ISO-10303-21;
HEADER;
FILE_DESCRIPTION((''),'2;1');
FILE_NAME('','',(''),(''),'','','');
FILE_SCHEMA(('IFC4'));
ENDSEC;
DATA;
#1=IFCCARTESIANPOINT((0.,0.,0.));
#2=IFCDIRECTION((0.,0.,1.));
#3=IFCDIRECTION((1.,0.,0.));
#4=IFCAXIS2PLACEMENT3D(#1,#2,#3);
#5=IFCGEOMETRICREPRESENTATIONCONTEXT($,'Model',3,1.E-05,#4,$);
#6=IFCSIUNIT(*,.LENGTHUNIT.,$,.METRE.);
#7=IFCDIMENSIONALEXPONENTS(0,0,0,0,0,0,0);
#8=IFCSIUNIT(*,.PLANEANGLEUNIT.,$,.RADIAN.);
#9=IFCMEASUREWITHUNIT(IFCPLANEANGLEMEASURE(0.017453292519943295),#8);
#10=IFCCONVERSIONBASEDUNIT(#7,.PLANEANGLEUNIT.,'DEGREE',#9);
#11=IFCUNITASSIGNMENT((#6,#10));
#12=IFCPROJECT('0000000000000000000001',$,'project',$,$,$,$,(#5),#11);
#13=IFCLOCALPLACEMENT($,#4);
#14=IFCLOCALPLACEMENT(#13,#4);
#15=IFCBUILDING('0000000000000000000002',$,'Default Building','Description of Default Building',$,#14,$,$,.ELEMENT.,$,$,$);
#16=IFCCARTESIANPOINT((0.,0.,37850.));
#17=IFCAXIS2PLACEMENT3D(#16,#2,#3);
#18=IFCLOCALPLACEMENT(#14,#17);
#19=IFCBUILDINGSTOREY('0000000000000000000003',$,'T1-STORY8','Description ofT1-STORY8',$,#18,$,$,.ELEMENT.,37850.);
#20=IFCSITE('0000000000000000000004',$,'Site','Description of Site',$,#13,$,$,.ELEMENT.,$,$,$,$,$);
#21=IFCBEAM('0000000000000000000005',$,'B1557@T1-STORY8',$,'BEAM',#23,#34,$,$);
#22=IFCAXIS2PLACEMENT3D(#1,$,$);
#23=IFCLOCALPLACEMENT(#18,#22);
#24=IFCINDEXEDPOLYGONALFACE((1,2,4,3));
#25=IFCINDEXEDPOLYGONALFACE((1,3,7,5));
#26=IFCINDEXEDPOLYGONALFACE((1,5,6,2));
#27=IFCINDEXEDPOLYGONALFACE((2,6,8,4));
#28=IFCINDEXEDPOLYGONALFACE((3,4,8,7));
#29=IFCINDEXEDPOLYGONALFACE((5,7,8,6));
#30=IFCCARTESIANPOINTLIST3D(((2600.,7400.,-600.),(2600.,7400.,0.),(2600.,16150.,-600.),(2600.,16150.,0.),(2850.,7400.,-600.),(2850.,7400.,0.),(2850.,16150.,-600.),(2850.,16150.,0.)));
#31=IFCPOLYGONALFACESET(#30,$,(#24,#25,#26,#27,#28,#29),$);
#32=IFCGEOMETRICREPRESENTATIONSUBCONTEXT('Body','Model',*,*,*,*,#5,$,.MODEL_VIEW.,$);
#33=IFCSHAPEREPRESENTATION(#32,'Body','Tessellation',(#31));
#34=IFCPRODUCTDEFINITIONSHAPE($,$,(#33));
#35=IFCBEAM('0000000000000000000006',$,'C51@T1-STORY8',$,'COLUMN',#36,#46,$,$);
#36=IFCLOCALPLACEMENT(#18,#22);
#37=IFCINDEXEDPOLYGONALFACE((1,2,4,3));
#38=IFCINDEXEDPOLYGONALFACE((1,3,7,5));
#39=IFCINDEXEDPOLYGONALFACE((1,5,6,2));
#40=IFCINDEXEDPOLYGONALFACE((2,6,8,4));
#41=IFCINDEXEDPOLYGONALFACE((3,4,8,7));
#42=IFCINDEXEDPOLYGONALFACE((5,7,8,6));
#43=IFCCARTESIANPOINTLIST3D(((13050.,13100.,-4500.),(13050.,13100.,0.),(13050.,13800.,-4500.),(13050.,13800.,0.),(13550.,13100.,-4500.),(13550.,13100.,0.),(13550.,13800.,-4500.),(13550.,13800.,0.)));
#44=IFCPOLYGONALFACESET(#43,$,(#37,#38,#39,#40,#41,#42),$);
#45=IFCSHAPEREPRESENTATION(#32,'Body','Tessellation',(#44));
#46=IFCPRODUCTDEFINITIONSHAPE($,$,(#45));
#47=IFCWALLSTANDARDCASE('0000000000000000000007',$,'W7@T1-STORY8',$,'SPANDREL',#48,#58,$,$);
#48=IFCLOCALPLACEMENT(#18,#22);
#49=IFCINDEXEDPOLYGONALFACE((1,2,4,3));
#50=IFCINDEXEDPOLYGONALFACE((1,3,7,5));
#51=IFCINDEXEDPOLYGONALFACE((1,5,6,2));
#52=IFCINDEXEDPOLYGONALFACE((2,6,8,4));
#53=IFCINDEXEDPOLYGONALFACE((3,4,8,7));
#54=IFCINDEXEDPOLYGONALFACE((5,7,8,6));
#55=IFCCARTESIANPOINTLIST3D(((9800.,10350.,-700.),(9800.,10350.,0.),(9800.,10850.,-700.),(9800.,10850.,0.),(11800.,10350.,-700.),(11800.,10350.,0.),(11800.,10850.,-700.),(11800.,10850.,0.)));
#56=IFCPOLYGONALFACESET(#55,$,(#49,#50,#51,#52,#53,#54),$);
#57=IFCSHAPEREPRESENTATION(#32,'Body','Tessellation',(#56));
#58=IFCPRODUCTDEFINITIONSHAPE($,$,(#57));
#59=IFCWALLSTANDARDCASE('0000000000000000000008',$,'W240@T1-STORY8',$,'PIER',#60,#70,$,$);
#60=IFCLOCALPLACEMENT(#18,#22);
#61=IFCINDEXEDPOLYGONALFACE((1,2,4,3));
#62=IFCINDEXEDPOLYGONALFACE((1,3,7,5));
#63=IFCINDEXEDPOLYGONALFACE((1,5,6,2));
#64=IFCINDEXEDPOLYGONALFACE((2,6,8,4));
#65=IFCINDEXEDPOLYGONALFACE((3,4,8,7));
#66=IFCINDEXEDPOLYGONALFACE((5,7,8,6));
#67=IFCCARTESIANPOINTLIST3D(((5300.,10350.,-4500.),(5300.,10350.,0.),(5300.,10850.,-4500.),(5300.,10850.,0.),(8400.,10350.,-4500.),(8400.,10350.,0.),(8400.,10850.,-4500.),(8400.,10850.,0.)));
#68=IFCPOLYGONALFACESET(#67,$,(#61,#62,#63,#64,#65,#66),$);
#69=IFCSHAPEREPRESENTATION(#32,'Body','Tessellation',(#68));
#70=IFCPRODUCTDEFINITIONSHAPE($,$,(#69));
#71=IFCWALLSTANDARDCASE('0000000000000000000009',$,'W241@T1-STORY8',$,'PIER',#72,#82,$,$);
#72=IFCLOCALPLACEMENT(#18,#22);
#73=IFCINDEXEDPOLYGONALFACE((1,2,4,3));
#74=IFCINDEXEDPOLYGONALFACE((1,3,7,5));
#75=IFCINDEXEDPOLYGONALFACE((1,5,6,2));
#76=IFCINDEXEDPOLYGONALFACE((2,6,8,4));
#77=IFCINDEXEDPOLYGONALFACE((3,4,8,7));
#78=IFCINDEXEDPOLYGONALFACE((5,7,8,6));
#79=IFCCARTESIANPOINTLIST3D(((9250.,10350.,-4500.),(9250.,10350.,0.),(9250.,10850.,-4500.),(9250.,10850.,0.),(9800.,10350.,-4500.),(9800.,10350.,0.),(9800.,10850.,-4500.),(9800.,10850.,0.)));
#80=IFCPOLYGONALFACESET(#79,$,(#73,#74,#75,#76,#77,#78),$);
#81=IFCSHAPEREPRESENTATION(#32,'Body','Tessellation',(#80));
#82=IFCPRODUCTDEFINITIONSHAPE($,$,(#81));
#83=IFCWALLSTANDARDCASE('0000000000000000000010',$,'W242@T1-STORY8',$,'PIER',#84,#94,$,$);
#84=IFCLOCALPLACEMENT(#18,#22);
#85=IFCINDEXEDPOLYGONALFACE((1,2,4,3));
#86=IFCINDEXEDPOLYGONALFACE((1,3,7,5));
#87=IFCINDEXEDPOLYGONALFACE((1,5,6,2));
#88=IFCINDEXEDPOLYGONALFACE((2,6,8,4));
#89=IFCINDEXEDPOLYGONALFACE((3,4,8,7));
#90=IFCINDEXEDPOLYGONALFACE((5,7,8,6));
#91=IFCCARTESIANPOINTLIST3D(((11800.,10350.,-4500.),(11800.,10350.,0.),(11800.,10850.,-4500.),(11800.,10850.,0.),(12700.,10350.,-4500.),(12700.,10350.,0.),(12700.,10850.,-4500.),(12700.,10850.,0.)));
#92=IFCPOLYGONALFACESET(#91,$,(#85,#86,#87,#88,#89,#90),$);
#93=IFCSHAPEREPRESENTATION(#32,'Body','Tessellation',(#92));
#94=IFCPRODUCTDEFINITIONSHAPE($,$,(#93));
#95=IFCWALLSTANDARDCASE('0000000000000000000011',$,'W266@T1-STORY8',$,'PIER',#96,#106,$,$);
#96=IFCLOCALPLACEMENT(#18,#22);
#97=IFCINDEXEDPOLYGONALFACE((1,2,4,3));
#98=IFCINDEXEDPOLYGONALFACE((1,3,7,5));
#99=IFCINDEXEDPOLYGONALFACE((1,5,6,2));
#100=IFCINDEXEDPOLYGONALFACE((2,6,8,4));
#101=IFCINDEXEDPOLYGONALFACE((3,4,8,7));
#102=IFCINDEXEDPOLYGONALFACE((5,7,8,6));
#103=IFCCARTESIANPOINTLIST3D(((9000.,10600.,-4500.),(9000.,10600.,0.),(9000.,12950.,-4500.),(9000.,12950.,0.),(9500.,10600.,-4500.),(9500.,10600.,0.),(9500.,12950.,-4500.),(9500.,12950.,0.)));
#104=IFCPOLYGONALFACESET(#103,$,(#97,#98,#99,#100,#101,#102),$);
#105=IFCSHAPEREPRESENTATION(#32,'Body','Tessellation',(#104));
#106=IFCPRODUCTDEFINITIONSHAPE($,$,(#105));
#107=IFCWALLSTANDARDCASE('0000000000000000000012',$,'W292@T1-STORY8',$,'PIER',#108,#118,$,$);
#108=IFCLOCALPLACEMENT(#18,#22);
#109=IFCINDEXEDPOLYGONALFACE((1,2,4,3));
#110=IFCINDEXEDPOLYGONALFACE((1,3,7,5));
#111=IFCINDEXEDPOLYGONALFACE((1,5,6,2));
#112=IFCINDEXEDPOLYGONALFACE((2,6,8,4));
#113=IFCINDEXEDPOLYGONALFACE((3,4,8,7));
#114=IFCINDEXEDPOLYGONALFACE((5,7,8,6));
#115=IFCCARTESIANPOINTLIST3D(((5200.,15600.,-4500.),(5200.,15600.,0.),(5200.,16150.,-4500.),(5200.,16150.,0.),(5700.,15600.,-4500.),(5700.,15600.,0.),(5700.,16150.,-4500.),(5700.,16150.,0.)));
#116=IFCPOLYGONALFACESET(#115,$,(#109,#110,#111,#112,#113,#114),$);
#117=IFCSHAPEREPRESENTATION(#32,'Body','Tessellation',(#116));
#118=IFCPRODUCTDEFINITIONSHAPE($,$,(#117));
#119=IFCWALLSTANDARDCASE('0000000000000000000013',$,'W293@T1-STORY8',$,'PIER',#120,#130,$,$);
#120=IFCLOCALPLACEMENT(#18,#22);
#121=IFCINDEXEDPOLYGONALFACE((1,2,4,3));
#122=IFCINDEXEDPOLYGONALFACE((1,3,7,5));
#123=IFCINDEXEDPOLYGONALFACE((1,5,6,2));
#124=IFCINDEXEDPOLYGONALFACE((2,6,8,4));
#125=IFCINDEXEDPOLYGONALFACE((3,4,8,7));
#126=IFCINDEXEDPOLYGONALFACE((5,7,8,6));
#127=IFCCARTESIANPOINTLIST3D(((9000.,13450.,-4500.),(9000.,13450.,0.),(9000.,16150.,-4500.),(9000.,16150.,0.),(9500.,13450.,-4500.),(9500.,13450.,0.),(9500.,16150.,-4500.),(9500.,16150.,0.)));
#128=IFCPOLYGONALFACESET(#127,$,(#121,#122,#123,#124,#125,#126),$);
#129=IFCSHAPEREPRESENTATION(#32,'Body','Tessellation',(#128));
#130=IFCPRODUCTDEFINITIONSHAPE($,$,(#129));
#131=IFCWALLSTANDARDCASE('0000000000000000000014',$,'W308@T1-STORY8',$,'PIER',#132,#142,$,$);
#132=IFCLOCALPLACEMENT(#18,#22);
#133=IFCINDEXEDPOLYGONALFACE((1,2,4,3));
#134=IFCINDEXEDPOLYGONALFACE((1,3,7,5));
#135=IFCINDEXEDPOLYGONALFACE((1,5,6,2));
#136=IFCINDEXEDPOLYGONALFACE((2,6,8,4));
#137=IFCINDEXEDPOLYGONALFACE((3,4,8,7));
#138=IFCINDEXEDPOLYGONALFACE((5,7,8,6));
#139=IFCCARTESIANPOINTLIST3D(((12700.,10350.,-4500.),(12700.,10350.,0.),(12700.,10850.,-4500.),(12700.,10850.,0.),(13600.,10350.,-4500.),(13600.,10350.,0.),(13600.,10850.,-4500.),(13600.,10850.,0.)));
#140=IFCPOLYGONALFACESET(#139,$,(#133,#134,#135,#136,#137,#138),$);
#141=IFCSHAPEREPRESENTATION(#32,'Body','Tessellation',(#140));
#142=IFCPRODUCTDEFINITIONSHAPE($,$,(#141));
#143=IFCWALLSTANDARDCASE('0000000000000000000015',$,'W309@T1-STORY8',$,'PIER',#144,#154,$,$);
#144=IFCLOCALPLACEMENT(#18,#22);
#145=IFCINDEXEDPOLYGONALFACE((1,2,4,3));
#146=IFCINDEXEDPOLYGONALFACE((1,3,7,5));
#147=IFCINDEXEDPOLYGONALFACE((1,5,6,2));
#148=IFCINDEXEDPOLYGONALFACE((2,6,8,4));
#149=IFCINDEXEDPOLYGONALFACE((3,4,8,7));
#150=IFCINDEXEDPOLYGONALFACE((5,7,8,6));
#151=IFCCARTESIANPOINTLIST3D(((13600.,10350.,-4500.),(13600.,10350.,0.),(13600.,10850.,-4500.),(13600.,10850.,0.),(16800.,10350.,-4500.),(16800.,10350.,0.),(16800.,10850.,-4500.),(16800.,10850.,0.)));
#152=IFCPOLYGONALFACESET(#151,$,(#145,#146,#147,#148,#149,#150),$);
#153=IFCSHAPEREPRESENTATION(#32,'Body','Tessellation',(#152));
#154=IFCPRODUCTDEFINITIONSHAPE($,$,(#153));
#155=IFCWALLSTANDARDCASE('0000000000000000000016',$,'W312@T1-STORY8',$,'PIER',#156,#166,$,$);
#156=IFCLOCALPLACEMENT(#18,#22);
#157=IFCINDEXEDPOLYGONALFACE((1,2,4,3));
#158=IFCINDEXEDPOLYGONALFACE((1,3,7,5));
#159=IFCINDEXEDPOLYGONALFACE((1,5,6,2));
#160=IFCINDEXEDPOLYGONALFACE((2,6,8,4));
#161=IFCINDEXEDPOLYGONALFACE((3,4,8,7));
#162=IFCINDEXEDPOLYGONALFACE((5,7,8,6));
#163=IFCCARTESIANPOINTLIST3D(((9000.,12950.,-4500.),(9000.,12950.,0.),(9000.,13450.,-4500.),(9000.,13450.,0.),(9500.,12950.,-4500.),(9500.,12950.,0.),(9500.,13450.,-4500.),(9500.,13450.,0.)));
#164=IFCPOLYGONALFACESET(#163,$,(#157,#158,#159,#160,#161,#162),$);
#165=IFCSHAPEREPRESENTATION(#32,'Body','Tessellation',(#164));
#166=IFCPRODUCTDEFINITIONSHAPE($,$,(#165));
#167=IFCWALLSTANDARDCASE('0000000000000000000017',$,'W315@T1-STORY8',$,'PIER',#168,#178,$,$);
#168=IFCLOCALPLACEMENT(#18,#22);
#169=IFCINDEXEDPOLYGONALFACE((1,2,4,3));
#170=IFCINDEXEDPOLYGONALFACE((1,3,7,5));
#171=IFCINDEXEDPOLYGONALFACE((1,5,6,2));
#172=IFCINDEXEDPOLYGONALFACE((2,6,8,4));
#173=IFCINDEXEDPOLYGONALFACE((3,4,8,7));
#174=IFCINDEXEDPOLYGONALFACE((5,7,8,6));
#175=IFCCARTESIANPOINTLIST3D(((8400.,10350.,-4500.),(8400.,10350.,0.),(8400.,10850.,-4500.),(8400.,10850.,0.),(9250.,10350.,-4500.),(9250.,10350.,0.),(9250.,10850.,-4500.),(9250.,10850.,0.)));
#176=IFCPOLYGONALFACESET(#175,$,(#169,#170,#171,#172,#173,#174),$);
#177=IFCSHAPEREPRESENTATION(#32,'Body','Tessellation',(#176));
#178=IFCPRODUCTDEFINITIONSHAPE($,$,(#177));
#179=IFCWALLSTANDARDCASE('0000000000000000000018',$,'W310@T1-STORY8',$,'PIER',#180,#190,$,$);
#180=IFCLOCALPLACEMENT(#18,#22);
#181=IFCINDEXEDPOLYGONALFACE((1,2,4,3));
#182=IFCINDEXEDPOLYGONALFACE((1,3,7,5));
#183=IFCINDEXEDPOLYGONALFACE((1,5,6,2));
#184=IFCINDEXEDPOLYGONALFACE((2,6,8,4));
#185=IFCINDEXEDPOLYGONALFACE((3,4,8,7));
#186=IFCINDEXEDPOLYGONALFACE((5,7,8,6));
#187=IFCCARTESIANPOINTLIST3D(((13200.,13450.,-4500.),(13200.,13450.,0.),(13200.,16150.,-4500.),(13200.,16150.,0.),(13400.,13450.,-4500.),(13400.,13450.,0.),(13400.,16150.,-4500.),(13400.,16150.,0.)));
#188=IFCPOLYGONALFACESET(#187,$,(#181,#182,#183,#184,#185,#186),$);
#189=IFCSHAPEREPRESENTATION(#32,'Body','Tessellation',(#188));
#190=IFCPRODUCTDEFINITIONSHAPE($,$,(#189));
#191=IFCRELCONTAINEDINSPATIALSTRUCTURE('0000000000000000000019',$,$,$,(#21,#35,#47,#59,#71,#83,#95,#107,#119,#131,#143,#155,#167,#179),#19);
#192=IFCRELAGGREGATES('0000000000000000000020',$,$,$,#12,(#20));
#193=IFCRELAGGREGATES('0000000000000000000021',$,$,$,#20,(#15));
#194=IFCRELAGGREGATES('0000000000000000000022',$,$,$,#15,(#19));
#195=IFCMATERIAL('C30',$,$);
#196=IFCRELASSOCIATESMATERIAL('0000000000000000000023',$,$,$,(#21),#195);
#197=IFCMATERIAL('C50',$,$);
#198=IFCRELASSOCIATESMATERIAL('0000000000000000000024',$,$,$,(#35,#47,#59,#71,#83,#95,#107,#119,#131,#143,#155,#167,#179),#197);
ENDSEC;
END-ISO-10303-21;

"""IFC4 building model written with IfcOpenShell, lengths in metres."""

from ifc_helpers import new_model, entity, si_unit, converted_unit, frame, origin_with_axes, place, context, subcontext, project, spatial, indexed_curve, rectangle, outline, extrude, material, element, save


model = new_model("IFC4")

# Units and contexts
model_context = context("Model", 3, precision=1e-05, world=origin_with_axes())
body_context = subcontext(model_context, "Body", "Model", "MODEL_VIEW")
ifc_project = project(units=[si_unit("LENGTHUNIT", "METRE"), converted_unit("PLANEANGLEUNIT", "DEGREE", entity("IfcPlaneAngleMeasure", 0.017453292519943295), si_unit("PLANEANGLEUNIT", "RADIAN"), dimensions=[0, 0, 0, 0, 0, 0, 0])], contexts=[model_context])

# Site, building, storey
site_placement = place(None, origin_with_axes())
site = spatial("IfcSite", under=ifc_project, at=site_placement, Name="Site", Description="Description of Site", CompositionType="ELEMENT")
building_placement = place(site_placement, origin_with_axes())
building = spatial("IfcBuilding", under=site, at=building_placement, Name="Default Building", Description="Description of Default Building", CompositionType="ELEMENT")
storey_placement = place(building_placement, frame((0.0, 0.0, 37850.0), z_axis=(0.0, 0.0, 1.0), x_axis=(1.0, 0.0, 0.0)))
storey = spatial("IfcBuildingStorey", under=building, at=storey_placement, Name="T1-STORY8", Description="Description ofT1-STORY8", CompositionType="ELEMENT", Elevation=37850.0)

# Beams
ifc_material_1 = material(Name="C30")
beam_1_placement = place(storey_placement, frame((2725.0, 7400.0, -300.0), z_axis=(0.0, 1.0, 0.0), x_axis=(-1.0, 0.0, 0.0)))
element("IfcBeam", 1, at=beam_1_placement, inside=storey, material=ifc_material_1, Name="B1557@T1-STORY8", ObjectType="BEAM", context=body_context, shape_type="SweptSolid", body=[
    extrude(rectangle(XDim=250.0, YDim=600.0), origin_with_axes(), (0.0, 0.0, 1.0), 8750.0),
])
ifc_material_2 = material(Name="C50")
beam_2_placement = place(storey_placement, frame((13300.0, 13450.0, -4500.0), z_axis=(0.0, 0.0, 1.0), x_axis=(-1.0, 0.0, 0.0)))
element("IfcBeam", 2, at=beam_2_placement, inside=storey, material=ifc_material_2, Name="C51@T1-STORY8", ObjectType="COLUMN", context=body_context, shape_type="SweptSolid", body=[
    extrude(rectangle(XDim=500.0, YDim=700.0), origin_with_axes(), (0.0, 0.0, 1.0), 4500.0),
])

# Walls
wall_1_placement = place(storey_placement, frame((9800.0, 10600.0, -700.0), z_axis=(0.0, 0.0, 1.0), x_axis=(1.0, 0.0, 0.0)))
element("IfcWallStandardCase", 3, at=wall_1_placement, inside=storey, material=ifc_material_2, Name="W7@T1-STORY8", ObjectType="SPANDREL", context=body_context, shape_type="SweptSolid", body=[
    extrude(outline(indexed_curve([(0.0, -250.0), (0.0, 250.0), (2000.0, 250.0), (2000.0, -250.0), (0.0, -250.0)], self_intersect=False)), origin_with_axes(), (0.0, 0.0, 1.0), 700.0),
])
wall_2_placement = place(storey_placement, frame((5300.0, 10600.0, -4500.0), z_axis=(0.0, 0.0, 1.0), x_axis=(1.0, 0.0, 0.0)))
element("IfcWallStandardCase", 4, at=wall_2_placement, inside=storey, material=ifc_material_2, Name="W240@T1-STORY8", ObjectType="PIER", context=body_context, shape_type="SweptSolid", body=[
    extrude(outline(indexed_curve([(0.0, -250.0), (0.0, 250.0), (3100.0, 250.0), (3100.0, -250.0), (0.0, -250.0)], self_intersect=False)), origin_with_axes(), (0.0, 0.0, 1.0), 4500.0),
])
wall_3_placement = place(storey_placement, frame((9250.0, 10600.0, -4500.0), z_axis=(0.0, 0.0, 1.0), x_axis=(1.0, 0.0, 0.0)))
element("IfcWallStandardCase", 5, at=wall_3_placement, inside=storey, material=ifc_material_2, Name="W241@T1-STORY8", ObjectType="PIER", context=body_context, shape_type="SweptSolid", body=[
    extrude(outline(indexed_curve([(0.0, -250.0), (0.0, 250.0), (550.0, 250.0), (550.0, -250.0), (0.0, -250.0)], self_intersect=False)), origin_with_axes(), (0.0, 0.0, 1.0), 4500.0),
])
wall_4_placement = place(storey_placement, frame((11800.0, 10600.0, -4500.0), z_axis=(0.0, 0.0, 1.0), x_axis=(1.0, 0.0, 0.0)))
element("IfcWallStandardCase", 6, at=wall_4_placement, inside=storey, material=ifc_material_2, Name="W242@T1-STORY8", ObjectType="PIER", context=body_context, shape_type="SweptSolid", body=[
    extrude(outline(indexed_curve([(0.0, -250.0), (0.0, 250.0), (900.0, 250.0), (900.0, -250.0), (0.0, -250.0)], self_intersect=False)), origin_with_axes(), (0.0, 0.0, 1.0), 4500.0),
])
wall_5_placement = place(storey_placement, frame((9250.0, 10600.0, -4500.0), z_axis=(0.0, 0.0, 1.0), x_axis=(0.0, 1.0, 0.0)))
element("IfcWallStandardCase", 7, at=wall_5_placement, inside=storey, material=ifc_material_2, Name="W266@T1-STORY8", ObjectType="PIER", context=body_context, shape_type="SweptSolid", body=[
    extrude(outline(indexed_curve([(0.0, -250.0), (0.0, 250.0), (2350.0, 250.0), (2350.0, -250.0), (0.0, -250.0)], self_intersect=False)), origin_with_axes(), (0.0, 0.0, 1.0), 4500.0),
])
wall_6_placement = place(storey_placement, frame((5450.0, 15600.0, -4500.0), z_axis=(0.0, 0.0, 1.0), x_axis=(0.0, 1.0, 0.0)))
element("IfcWallStandardCase", 8, at=wall_6_placement, inside=storey, material=ifc_material_2, Name="W292@T1-STORY8", ObjectType="PIER", context=body_context, shape_type="SweptSolid", body=[
    extrude(outline(indexed_curve([(0.0, -250.0), (0.0, 250.0), (550.0, 250.0), (550.0, -250.0), (0.0, -250.0)], self_intersect=False)), origin_with_axes(), (0.0, 0.0, 1.0), 4500.0),
])
wall_7_placement = place(storey_placement, frame((9250.0, 13450.0, -4500.0), z_axis=(0.0, 0.0, 1.0), x_axis=(0.0, 1.0, 0.0)))
element("IfcWallStandardCase", 9, at=wall_7_placement, inside=storey, material=ifc_material_2, Name="W293@T1-STORY8", ObjectType="PIER", context=body_context, shape_type="SweptSolid", body=[
    extrude(outline(indexed_curve([(0.0, -250.0), (0.0, 250.0), (2700.0, 250.0), (2700.0, -250.0), (0.0, -250.0)], self_intersect=False)), origin_with_axes(), (0.0, 0.0, 1.0), 4500.0),
])
wall_8_placement = place(storey_placement, frame((12700.0, 10600.0, -4500.0), z_axis=(0.0, 0.0, 1.0), x_axis=(1.0, 0.0, 0.0)))
element("IfcWallStandardCase", 10, at=wall_8_placement, inside=storey, material=ifc_material_2, Name="W308@T1-STORY8", ObjectType="PIER", context=body_context, shape_type="SweptSolid", body=[
    extrude(outline(indexed_curve([(0.0, -250.0), (0.0, 250.0), (900.0, 250.0), (900.0, -250.0), (0.0, -250.0)], self_intersect=False)), origin_with_axes(), (0.0, 0.0, 1.0), 4500.0),
])
wall_9_placement = place(storey_placement, frame((13600.0, 10600.0, -4500.0), z_axis=(0.0, 0.0, 1.0), x_axis=(1.0, 0.0, 0.0)))
element("IfcWallStandardCase", 11, at=wall_9_placement, inside=storey, material=ifc_material_2, Name="W309@T1-STORY8", ObjectType="PIER", context=body_context, shape_type="SweptSolid", body=[
    extrude(outline(indexed_curve([(0.0, -250.0), (0.0, 250.0), (3200.0, 250.0), (3200.0, -250.0), (0.0, -250.0)], self_intersect=False)), origin_with_axes(), (0.0, 0.0, 1.0), 4500.0),
])
wall_10_placement = place(storey_placement, frame((9250.0, 12950.0, -4500.0), z_axis=(0.0, 0.0, 1.0), x_axis=(0.0, 1.0, 0.0)))
element("IfcWallStandardCase", 12, at=wall_10_placement, inside=storey, material=ifc_material_2, Name="W312@T1-STORY8", ObjectType="PIER", context=body_context, shape_type="SweptSolid", body=[
    extrude(outline(indexed_curve([(0.0, -250.0), (0.0, 250.0), (500.0, 250.0), (500.0, -250.0), (0.0, -250.0)], self_intersect=False)), origin_with_axes(), (0.0, 0.0, 1.0), 4500.0),
])
wall_11_placement = place(storey_placement, frame((8400.0, 10600.0, -4500.0), z_axis=(0.0, 0.0, 1.0), x_axis=(1.0, 0.0, 0.0)))
element("IfcWallStandardCase", 13, at=wall_11_placement, inside=storey, material=ifc_material_2, Name="W315@T1-STORY8", ObjectType="PIER", context=body_context, shape_type="SweptSolid", body=[
    extrude(outline(indexed_curve([(0.0, -250.0), (0.0, 250.0), (850.0, 250.0), (850.0, -250.0), (0.0, -250.0)], self_intersect=False)), origin_with_axes(), (0.0, 0.0, 1.0), 4500.0),
])
wall_12_placement = place(storey_placement, frame((13300.0, 13450.0, -4500.0), z_axis=(0.0, 0.0, 1.0), x_axis=(0.0, 1.0, 0.0)))
element("IfcWallStandardCase", 14, at=wall_12_placement, inside=storey, material=ifc_material_2, Name="W310@T1-STORY8", ObjectType="PIER", context=body_context, shape_type="SweptSolid", body=[
    extrude(outline(indexed_curve([(0.0, -100.0), (0.0, 100.0), (2700.0, 100.0), (2700.0, -100.0), (0.0, -100.0)], self_intersect=False)), origin_with_axes(), (0.0, 0.0, 1.0), 4500.0),
])

save(model, "model.ifc")
